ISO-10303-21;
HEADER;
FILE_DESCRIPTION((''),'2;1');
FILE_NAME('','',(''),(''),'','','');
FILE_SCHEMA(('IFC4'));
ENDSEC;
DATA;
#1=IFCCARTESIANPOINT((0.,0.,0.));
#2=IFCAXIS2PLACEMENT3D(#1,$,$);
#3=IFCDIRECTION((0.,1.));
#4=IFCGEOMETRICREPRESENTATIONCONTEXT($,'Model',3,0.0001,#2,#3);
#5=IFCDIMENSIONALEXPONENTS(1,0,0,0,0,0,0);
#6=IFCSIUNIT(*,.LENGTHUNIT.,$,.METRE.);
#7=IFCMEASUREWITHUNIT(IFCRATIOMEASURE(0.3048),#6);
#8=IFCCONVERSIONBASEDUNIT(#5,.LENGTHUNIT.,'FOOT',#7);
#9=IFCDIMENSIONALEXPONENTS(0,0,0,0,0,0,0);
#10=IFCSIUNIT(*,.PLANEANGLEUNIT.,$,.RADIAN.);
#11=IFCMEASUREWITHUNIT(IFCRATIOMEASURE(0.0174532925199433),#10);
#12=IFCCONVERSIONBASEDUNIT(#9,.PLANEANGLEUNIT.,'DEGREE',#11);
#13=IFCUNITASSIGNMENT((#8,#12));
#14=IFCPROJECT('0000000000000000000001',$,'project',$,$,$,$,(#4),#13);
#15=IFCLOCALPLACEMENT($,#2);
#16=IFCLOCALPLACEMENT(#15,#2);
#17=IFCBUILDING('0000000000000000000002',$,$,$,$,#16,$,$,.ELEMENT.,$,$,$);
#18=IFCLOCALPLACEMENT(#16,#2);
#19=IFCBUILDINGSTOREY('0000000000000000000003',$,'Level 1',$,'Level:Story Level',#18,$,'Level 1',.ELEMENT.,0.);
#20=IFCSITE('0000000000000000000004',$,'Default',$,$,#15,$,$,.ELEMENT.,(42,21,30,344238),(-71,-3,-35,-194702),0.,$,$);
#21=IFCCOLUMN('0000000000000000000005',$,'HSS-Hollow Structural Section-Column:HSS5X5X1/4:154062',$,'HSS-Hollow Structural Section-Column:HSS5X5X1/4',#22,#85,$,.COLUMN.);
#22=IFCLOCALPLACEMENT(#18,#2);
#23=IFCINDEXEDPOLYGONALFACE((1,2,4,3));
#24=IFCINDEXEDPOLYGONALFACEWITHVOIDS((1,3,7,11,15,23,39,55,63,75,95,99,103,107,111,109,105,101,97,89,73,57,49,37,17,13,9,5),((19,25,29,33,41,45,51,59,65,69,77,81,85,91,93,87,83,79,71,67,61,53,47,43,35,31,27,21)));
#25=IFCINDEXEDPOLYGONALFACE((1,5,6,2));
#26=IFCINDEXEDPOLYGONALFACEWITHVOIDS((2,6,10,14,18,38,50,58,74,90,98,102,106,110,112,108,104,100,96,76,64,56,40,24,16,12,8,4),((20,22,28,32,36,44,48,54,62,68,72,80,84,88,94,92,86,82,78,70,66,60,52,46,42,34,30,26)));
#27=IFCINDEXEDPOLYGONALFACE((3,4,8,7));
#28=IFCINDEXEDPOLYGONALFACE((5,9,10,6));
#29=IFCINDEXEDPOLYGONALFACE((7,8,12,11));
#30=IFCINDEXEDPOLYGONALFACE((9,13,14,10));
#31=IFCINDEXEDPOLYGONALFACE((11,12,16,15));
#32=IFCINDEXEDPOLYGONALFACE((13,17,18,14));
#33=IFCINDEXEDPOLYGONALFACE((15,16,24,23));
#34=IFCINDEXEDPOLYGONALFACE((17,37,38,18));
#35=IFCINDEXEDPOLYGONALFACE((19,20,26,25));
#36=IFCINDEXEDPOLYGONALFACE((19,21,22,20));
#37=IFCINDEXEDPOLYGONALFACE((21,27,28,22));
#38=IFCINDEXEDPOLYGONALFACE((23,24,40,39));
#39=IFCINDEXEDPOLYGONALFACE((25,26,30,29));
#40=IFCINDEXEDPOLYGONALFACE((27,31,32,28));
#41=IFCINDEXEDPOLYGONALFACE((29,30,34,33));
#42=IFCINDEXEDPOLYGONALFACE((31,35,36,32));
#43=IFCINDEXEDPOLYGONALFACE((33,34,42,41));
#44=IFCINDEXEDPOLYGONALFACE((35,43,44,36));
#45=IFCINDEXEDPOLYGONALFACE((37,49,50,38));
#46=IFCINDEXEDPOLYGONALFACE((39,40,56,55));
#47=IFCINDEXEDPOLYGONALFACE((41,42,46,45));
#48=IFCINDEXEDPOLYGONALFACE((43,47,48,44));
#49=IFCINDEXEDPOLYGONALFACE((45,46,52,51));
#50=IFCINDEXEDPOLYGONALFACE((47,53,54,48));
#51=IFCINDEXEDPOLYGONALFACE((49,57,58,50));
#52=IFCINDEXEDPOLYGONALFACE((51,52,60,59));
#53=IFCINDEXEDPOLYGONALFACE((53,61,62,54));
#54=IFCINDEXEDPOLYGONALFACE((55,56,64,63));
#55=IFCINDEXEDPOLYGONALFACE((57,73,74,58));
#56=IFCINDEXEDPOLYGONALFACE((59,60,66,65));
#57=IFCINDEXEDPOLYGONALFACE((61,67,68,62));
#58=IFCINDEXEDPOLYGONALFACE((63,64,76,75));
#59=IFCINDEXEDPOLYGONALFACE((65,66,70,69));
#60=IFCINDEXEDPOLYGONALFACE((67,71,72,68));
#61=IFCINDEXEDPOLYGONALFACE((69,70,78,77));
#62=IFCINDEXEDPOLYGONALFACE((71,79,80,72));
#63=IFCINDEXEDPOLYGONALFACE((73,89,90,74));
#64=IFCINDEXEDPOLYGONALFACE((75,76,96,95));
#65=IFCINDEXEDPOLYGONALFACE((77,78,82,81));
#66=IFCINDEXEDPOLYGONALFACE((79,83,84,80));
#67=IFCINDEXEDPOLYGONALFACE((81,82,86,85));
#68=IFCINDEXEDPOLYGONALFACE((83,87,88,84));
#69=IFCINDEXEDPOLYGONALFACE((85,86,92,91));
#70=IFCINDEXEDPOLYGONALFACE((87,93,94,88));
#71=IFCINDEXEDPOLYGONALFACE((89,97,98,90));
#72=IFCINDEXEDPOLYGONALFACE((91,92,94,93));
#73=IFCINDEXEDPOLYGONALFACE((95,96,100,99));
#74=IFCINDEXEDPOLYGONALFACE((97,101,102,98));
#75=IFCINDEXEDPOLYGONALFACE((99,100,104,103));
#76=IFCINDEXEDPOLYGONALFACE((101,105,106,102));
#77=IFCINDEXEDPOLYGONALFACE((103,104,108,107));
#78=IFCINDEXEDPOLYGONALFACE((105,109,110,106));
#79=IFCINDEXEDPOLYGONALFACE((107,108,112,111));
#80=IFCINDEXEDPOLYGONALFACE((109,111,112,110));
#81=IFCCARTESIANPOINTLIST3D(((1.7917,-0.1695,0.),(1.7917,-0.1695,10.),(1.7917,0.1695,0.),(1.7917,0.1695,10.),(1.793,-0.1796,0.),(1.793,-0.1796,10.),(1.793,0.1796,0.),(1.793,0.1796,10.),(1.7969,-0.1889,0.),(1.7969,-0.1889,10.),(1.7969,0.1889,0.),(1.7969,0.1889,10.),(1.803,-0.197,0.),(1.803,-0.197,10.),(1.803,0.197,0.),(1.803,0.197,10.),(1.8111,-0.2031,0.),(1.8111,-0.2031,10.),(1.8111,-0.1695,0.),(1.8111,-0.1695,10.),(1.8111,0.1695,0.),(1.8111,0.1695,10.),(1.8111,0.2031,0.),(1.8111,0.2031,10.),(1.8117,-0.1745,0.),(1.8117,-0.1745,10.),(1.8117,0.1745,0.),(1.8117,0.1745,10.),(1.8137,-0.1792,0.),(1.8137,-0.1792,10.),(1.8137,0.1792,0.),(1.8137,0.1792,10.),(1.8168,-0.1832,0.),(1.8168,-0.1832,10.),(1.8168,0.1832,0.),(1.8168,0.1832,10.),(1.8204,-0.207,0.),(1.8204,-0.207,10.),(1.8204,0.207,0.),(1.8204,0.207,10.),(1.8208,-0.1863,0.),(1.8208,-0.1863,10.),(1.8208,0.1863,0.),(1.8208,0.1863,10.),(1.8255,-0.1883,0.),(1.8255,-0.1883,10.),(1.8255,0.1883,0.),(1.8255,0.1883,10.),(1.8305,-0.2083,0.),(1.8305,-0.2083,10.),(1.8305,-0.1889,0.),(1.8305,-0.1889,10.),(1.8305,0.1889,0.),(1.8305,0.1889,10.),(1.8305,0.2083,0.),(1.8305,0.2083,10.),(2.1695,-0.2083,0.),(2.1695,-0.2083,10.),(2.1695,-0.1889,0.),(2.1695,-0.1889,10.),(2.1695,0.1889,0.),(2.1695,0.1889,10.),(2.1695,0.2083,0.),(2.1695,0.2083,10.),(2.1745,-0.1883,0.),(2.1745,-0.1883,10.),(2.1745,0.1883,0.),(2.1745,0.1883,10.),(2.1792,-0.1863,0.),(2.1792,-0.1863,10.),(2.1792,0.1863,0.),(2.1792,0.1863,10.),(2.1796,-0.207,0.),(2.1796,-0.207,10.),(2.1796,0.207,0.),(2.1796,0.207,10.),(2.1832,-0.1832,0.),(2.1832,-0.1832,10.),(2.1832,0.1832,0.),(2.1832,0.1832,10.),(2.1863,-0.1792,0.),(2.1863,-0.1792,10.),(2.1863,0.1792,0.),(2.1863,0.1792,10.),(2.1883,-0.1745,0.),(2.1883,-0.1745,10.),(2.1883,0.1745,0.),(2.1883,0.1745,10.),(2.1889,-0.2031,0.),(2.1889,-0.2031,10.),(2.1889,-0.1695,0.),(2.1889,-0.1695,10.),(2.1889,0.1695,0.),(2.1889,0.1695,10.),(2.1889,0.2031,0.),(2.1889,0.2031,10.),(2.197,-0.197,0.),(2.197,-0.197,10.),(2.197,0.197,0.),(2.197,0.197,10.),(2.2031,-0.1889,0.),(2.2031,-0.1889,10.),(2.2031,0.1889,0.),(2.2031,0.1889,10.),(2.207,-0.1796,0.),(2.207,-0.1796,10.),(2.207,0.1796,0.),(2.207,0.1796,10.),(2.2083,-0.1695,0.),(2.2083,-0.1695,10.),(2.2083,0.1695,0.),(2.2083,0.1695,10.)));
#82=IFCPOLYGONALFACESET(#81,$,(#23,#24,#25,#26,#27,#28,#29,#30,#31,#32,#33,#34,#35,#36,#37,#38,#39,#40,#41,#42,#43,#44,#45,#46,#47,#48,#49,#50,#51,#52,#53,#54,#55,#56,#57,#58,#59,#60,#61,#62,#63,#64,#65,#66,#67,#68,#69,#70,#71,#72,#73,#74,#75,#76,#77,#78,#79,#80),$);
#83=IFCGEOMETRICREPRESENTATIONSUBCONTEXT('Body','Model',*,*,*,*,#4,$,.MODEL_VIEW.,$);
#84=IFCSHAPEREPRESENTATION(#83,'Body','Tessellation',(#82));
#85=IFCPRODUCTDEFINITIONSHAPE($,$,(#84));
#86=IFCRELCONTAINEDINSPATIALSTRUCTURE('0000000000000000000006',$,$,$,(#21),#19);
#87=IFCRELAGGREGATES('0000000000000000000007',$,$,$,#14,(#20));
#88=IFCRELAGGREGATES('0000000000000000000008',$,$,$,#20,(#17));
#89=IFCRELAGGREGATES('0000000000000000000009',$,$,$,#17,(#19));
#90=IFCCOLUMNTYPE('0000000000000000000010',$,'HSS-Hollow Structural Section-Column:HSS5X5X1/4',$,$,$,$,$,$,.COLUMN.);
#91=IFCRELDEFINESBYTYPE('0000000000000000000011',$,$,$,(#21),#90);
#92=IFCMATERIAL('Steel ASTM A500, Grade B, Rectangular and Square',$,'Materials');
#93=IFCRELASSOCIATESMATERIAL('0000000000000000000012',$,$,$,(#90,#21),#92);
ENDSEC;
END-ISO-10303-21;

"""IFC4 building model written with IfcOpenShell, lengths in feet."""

from ifc_helpers import new_model, entity, si_unit, converted_unit, direction, frame, frame_2d, origin, place, context, subcontext, project, spatial, polyline, circle_curve, parameter, trimmed, segment, composite_curve, outline, extrude, source, transform, mapped, material, material_profile, profile_set, profile_usage, type_object, type_shapes, element, save


model = new_model("IFC4")

# Units and contexts
model_context = context("Model", 3, precision=0.0001, world=origin(), true_north=direction((0.0, 1.0)))
body_context = subcontext(model_context, "Body", "Model", "MODEL_VIEW")
ifc_project = project(units=[converted_unit("LENGTHUNIT", "FOOT", entity("IfcRatioMeasure", 0.3048), si_unit("LENGTHUNIT", "METRE"), dimensions=[1, 0, 0, 0, 0, 0, 0]), converted_unit("PLANEANGLEUNIT", "DEGREE", entity("IfcRatioMeasure", 0.0174532925199433), si_unit("PLANEANGLEUNIT", "RADIAN"), dimensions=[0, 0, 0, 0, 0, 0, 0])], contexts=[model_context])

# Site, building, storey
site_placement = place(None, origin())
site = spatial("IfcSite", under=ifc_project, at=site_placement, Name="Default", CompositionType="ELEMENT", RefLatitude=(42, 21, 30, 344238), RefLongitude=(-71, -3, -35, -194702), RefElevation=0.0)
building_placement = place(site_placement, origin())
building = spatial("IfcBuilding", under=site, at=building_placement, CompositionType="ELEMENT")
storey_placement = place(building_placement, origin())
storey = spatial("IfcBuildingStorey", under=building, at=storey_placement, Name="Level 1", ObjectType="Level:Story Level", LongName="Level 1", CompositionType="ELEMENT", Elevation=0.0)

# Column
ifc_material = material(Name="Steel ASTM A500, Grade B, Rectangular and Square", Category="Materials")
ifc_material_profile = material_profile(ifc_material, outline(composite_curve([segment(polyline([(-0.1695, -0.2083), (0.1695, -0.2083)]), True, "CONTINUOUS"), segment(trimmed(circle_curve(frame_2d((0.1695, -0.1695), x_axis=(-1.0, 0.0)), 0.0388), [parameter(90.0)], [parameter(180.0)], True, "PARAMETER"), True, "CONTINUOUS"), segment(polyline([(0.2083, -0.1695), (0.2083, 0.1695)]), True, "CONTINUOUS"), segment(trimmed(circle_curve(frame_2d((0.1695, 0.1695), x_axis=(-1.0, 0.0)), 0.0388), [parameter(180.0)], [parameter(270.0)], True, "PARAMETER"), True, "CONTINUOUS"), segment(polyline([(0.1695, 0.2083), (-0.1695, 0.2083)]), True, "CONTINUOUS"), segment(trimmed(circle_curve(frame_2d((-0.1695, 0.1695), x_axis=(-1.0, 0.0)), 0.0388), [parameter(270.0)], [parameter(360.0)], True, "PARAMETER"), True, "CONTINUOUS"), segment(polyline([(-0.2083, 0.1695), (-0.2083, -0.1695)]), True, "CONTINUOUS"), segment(trimmed(circle_curve(frame_2d((-0.1695, -0.1695), x_axis=(-1.0, 0.0)), 0.0388), [parameter(360.0)], [parameter(90.0)], True, "PARAMETER"), True, "CONTINUOUS")], self_intersect=False), holes=[composite_curve([segment(trimmed(circle_curve(frame_2d((-0.1695, -0.1695), x_axis=(-1.0, 0.0)), 0.0194), [parameter(0.0)], [parameter(90.0)], True, "PARAMETER"), False, "CONTINUOUS"), segment(polyline([(-0.1889, -0.1695), (-0.1889, 0.1695)]), True, "CONTINUOUS"), segment(trimmed(circle_curve(frame_2d((-0.1695, 0.1695), x_axis=(-1.0, 0.0)), 0.0194), [parameter(270.0)], [parameter(360.0)], True, "PARAMETER"), False, "CONTINUOUS"), segment(polyline([(-0.1695, 0.1889), (0.1695, 0.1889)]), True, "CONTINUOUS"), segment(trimmed(circle_curve(frame_2d((0.1695, 0.1695), x_axis=(-1.0, 0.0)), 0.0194), [parameter(180.0)], [parameter(270.0)], True, "PARAMETER"), False, "CONTINUOUS"), segment(polyline([(0.1889, 0.1695), (0.1889, -0.1695)]), True, "CONTINUOUS"), segment(trimmed(circle_curve(frame_2d((0.1695, -0.1695), x_axis=(-1.0, 0.0)), 0.0194), [parameter(90.0)], [parameter(180.0)], True, "PARAMETER"), False, "CONTINUOUS"), segment(polyline([(0.1695, -0.1889), (-0.1695, -0.1889)]), True, "CONTINUOUS")], self_intersect=False)]), Name="HSS5X5X1/4")
ifc_profile_set = profile_set([ifc_material_profile], Name="HSS5X5X1/4")
column_type = type_object("IfcColumnType", Name="HSS-Hollow Structural Section-Column:HSS5X5X1/4", PredefinedType="COLUMN", material=ifc_profile_set)
shared_shape = source(origin(), body_context, "Body", "SweptSolid", [
    extrude(outline(composite_curve([segment(polyline([(-0.1695, -0.2083), (0.1695, -0.2083)]), True, "CONTINUOUS"), segment(trimmed(circle_curve(frame_2d((0.1695, -0.1695), x_axis=(-1.0, 0.0)), 0.0388), [parameter(90.0)], [parameter(180.0)], True, "PARAMETER"), True, "CONTINUOUS"), segment(polyline([(0.2083, -0.1695), (0.2083, 0.1695)]), True, "CONTINUOUS"), segment(trimmed(circle_curve(frame_2d((0.1695, 0.1695), x_axis=(-1.0, 0.0)), 0.0388), [parameter(180.0)], [parameter(270.0)], True, "PARAMETER"), True, "CONTINUOUS"), segment(polyline([(0.1695, 0.2083), (-0.1695, 0.2083)]), True, "CONTINUOUS"), segment(trimmed(circle_curve(frame_2d((-0.1695, 0.1695), x_axis=(-1.0, 0.0)), 0.0388), [parameter(270.0)], [parameter(360.0)], True, "PARAMETER"), True, "CONTINUOUS"), segment(polyline([(-0.2083, 0.1695), (-0.2083, -0.1695)]), True, "CONTINUOUS"), segment(trimmed(circle_curve(frame_2d((-0.1695, -0.1695), x_axis=(-1.0, 0.0)), 0.0388), [parameter(360.0)], [parameter(90.0)], True, "PARAMETER"), True, "CONTINUOUS")], self_intersect=False), holes=[composite_curve([segment(trimmed(circle_curve(frame_2d((-0.1695, -0.1695), x_axis=(-1.0, 0.0)), 0.0194), [parameter(0.0)], [parameter(90.0)], True, "PARAMETER"), False, "CONTINUOUS"), segment(polyline([(-0.1889, -0.1695), (-0.1889, 0.1695)]), True, "CONTINUOUS"), segment(trimmed(circle_curve(frame_2d((-0.1695, 0.1695), x_axis=(-1.0, 0.0)), 0.0194), [parameter(270.0)], [parameter(360.0)], True, "PARAMETER"), False, "CONTINUOUS"), segment(polyline([(-0.1695, 0.1889), (0.1695, 0.1889)]), True, "CONTINUOUS"), segment(trimmed(circle_curve(frame_2d((0.1695, 0.1695), x_axis=(-1.0, 0.0)), 0.0194), [parameter(180.0)], [parameter(270.0)], True, "PARAMETER"), False, "CONTINUOUS"), segment(polyline([(0.1889, 0.1695), (0.1889, -0.1695)]), True, "CONTINUOUS"), segment(trimmed(circle_curve(frame_2d((0.1695, -0.1695), x_axis=(-1.0, 0.0)), 0.0194), [parameter(90.0)], [parameter(180.0)], True, "PARAMETER"), False, "CONTINUOUS"), segment(polyline([(0.1695, -0.1889), (-0.1695, -0.1889)]), True, "CONTINUOUS")], self_intersect=False)]), frame((0.0, 0.0, 0.0), z_axis=(0.0, 0.0, 1.0), x_axis=(-1.0, 0.0, 0.0)), (0.0, 0.0, 1.0), 10.0),
])
type_shapes(column_type, [shared_shape])
ifc_profile_usage_1 = profile_usage(ifc_profile_set)
column_1_placement = place(storey_placement, frame((2.0, 0.0, 0.0)))
element("IfcColumn", 1, at=column_1_placement, inside=storey, type_object=column_type, material=ifc_profile_usage_1, Name="HSS-Hollow Structural Section-Column:HSS5X5X1/4:154062", ObjectType="HSS-Hollow Structural Section-Column:HSS5X5X1/4", PredefinedType="COLUMN", context=body_context, shape_type="MappedRepresentation", body=[
    mapped(shared_shape, transform((0.0, 0.0, 0.0), scale=1.0)),
])

save(model, "model.ifc")
